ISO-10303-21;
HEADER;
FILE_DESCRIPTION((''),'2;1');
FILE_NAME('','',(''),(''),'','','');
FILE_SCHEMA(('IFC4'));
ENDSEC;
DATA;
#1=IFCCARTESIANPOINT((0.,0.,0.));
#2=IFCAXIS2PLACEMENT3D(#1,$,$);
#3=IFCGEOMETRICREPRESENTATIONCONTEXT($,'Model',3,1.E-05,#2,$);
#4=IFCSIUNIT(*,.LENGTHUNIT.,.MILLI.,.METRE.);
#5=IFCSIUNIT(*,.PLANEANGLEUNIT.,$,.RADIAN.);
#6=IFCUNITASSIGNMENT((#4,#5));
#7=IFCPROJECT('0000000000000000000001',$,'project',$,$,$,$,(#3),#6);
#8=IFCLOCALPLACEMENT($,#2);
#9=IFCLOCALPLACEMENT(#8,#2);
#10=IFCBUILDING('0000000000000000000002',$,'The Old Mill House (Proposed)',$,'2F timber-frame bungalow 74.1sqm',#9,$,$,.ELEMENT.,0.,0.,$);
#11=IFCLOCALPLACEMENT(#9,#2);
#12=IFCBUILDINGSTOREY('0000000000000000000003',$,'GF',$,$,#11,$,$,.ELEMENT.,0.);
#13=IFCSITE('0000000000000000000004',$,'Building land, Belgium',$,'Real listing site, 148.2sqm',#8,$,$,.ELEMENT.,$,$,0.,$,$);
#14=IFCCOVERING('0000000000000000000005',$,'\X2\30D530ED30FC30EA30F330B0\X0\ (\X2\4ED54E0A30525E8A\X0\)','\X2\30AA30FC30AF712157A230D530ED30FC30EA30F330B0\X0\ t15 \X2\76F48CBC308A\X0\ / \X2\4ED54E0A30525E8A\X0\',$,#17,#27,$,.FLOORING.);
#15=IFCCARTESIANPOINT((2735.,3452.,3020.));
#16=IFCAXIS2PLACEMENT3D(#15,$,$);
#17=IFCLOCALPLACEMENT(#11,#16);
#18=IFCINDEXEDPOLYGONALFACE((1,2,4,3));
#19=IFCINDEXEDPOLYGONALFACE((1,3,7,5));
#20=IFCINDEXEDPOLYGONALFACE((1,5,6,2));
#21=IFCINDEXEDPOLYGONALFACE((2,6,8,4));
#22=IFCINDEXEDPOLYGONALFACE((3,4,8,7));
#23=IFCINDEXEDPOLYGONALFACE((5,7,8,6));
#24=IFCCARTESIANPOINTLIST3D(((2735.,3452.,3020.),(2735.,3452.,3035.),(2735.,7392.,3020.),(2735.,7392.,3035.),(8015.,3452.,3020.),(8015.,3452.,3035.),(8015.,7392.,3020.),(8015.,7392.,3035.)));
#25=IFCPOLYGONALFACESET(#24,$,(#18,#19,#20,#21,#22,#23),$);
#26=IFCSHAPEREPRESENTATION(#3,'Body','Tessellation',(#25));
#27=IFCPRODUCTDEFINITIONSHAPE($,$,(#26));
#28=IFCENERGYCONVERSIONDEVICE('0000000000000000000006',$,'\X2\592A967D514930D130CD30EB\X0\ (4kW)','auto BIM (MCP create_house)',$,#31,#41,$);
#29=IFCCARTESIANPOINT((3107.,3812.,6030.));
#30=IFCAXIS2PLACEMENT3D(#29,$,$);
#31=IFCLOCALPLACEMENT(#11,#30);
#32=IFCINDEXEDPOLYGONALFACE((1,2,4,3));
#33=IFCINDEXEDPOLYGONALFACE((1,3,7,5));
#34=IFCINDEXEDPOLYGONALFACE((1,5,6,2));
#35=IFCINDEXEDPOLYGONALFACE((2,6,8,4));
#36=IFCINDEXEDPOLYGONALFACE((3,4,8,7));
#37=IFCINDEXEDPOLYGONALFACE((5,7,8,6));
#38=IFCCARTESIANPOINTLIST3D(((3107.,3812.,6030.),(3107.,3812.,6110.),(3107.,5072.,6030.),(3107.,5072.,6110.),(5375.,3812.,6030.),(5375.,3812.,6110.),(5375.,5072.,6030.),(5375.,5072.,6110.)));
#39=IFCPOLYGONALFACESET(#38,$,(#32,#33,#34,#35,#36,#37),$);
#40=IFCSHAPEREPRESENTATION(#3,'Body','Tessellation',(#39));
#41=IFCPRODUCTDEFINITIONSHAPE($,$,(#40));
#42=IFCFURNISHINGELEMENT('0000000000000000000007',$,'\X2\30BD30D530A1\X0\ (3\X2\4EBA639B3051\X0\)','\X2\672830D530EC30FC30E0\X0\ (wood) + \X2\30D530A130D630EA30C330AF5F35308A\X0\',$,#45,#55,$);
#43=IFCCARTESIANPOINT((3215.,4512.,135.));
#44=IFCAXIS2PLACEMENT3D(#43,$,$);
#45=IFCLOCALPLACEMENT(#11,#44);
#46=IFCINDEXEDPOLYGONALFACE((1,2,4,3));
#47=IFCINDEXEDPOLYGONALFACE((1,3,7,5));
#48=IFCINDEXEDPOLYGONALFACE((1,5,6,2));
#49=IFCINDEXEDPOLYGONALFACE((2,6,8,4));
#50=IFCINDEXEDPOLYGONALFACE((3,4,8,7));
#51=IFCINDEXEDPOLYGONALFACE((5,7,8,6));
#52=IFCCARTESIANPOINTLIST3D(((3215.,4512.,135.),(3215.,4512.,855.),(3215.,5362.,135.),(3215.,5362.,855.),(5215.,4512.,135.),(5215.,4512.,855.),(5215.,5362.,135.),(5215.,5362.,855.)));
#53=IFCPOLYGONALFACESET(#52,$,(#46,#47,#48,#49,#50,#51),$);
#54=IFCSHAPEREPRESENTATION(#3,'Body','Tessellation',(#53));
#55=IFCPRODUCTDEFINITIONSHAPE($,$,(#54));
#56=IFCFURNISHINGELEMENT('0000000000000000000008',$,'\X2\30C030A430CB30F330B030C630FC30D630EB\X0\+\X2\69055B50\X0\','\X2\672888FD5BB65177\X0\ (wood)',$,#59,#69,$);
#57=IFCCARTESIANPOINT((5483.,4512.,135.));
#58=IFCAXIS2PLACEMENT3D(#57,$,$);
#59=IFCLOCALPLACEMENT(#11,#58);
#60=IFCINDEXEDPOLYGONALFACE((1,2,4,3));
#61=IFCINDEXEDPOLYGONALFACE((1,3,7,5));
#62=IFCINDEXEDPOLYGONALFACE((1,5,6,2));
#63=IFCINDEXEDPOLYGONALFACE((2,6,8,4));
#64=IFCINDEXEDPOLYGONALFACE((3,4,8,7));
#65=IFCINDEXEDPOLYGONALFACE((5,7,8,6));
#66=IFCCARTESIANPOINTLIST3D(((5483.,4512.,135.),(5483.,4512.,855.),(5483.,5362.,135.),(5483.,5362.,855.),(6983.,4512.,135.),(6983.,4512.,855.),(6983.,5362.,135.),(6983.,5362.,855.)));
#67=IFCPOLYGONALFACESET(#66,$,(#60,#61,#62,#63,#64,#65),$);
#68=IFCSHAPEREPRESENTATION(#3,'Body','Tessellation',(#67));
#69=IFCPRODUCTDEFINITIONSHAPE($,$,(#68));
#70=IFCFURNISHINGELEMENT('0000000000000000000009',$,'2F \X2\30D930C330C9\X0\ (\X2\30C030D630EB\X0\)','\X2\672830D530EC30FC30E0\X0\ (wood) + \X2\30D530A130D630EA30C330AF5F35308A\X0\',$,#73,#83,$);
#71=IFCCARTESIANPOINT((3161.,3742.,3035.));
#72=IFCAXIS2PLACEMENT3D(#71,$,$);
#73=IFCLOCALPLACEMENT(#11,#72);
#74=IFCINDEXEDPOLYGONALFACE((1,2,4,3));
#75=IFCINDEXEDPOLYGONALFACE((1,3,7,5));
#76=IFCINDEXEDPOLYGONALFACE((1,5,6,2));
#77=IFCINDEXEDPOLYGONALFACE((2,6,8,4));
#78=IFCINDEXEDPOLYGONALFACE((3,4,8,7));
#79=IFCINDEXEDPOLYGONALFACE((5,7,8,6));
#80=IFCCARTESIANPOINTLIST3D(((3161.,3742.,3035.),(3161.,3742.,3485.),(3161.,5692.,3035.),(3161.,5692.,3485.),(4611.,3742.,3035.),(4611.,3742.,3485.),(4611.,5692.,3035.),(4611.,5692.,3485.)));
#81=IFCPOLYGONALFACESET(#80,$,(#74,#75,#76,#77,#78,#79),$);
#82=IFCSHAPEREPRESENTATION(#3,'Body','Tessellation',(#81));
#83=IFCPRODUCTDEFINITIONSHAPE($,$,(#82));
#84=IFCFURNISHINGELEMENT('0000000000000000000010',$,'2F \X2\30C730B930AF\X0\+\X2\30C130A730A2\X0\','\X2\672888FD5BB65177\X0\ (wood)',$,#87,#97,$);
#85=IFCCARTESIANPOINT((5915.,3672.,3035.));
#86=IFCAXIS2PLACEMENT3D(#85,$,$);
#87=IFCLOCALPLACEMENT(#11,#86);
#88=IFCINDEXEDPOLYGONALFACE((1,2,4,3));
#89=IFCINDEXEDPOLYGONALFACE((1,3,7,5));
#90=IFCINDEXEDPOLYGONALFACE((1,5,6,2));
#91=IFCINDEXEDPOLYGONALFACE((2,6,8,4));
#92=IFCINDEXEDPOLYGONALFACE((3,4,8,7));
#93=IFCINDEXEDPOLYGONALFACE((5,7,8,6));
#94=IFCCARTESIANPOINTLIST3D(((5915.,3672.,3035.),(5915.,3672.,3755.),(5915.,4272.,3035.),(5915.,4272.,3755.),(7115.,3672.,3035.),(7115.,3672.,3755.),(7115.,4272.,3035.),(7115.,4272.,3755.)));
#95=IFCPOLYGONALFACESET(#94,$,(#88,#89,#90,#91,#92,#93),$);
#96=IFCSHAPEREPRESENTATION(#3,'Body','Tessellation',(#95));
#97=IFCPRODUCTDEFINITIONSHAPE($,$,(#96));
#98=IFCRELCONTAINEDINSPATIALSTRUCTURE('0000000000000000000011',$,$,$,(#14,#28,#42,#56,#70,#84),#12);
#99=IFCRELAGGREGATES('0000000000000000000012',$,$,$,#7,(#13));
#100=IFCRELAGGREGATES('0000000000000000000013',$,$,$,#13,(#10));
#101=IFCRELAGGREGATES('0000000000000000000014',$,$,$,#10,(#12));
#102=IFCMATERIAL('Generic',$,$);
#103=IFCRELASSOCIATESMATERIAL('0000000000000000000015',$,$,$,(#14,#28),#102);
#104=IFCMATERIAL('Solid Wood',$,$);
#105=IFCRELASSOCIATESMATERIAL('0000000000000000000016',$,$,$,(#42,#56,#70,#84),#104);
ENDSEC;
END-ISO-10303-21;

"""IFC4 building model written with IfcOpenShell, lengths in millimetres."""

from ifc_helpers import new_model, si_unit, frame, frame_2d, origin, place, context, project, spatial, rectangle, extrude, material, element, save


model = new_model("IFC4")

# Units and contexts
model_context = context("Model", 3, precision=1e-05, world=origin())
ifc_project = project(units=[si_unit("LENGTHUNIT", "METRE", prefix="MILLI"), si_unit("PLANEANGLEUNIT", "RADIAN")], contexts=[model_context])

# Site, building, storey
site_placement = place(None, origin())
site = spatial("IfcSite", under=ifc_project, at=site_placement, Name="Building land, Belgium", ObjectType="Real listing site, 148.2sqm", CompositionType="ELEMENT", RefElevation=0.0)
building_placement = place(site_placement, origin())
building = spatial("IfcBuilding", under=site, at=building_placement, Name="The Old Mill House (Proposed)", ObjectType="2F timber-frame bungalow 74.1sqm", CompositionType="ELEMENT", ElevationOfRefHeight=0.0, ElevationOfTerrain=0.0)
storey_placement = place(building_placement, origin())
storey = spatial("IfcBuildingStorey", under=building, at=storey_placement, Name="GF", CompositionType="ELEMENT", Elevation=0.0)

# Shared definitions
ifc_material_1 = material(Name="Solid Wood")

# Covering
ifc_material_2 = material(Name="Generic")
covering_placement = place(storey_placement, frame((2735.0, 3452.0, 3020.0)))
element("IfcCovering", 1, at=covering_placement, inside=storey, material=ifc_material_2, Name="フローリング (仕上げ床)", Description="オーク無垢フローリング t15 直貼り / 仕上げ床", PredefinedType="FLOORING", context=model_context, shape_type="SweptSolid", body=[
    extrude(rectangle(XDim=5280.0, YDim=3940.0, at=frame_2d((2640.0, 1970.0))), frame((2735.0, 3452.0, 3020.0)), (0.0, 0.0, 1.0), 15.0),
])

# Energy conversion device
energy_conversion_device_placement = place(storey_placement, frame((3107.0, 3812.0, 6030.0)))
element("IfcEnergyConversionDevice", 2, at=energy_conversion_device_placement, inside=storey, material=ifc_material_2, Name="太陽光パネル (4kW)", Description="auto BIM (MCP create_house)", context=model_context, shape_type="SweptSolid", body=[
    extrude(rectangle(XDim=2268.0, YDim=1260.0, at=frame_2d((1134.0, 630.0))), frame((3107.0, 3812.0, 6030.0)), (0.0, 0.0, 1.0), 80.0),
])

# Furnishing elements
furnishing_1_placement = place(storey_placement, frame((3215.0, 4512.0, 135.0)))
element("IfcFurnishingElement", 3, at=furnishing_1_placement, inside=storey, material=ifc_material_1, Name="ソファ (3人掛け)", Description="木フレーム (wood) + ファブリック張り", context=model_context, shape_type="SweptSolid", body=[
    extrude(rectangle(XDim=2000.0, YDim=850.0, at=frame_2d((1000.0, 425.0))), frame((3215.0, 4512.0, 135.0)), (0.0, 0.0, 1.0), 720.0),
])
furnishing_2_placement = place(storey_placement, frame((5483.0, 4512.0, 135.0)))
element("IfcFurnishingElement", 4, at=furnishing_2_placement, inside=storey, material=ifc_material_1, Name="ダイニングテーブル+椅子", Description="木製家具 (wood)", context=model_context, shape_type="SweptSolid", body=[
    extrude(rectangle(XDim=1500.0, YDim=850.0, at=frame_2d((750.0, 425.0))), frame((5483.0, 4512.0, 135.0)), (0.0, 0.0, 1.0), 720.0),
])
furnishing_3_placement = place(storey_placement, frame((3161.0, 3742.0, 3035.0)))
element("IfcFurnishingElement", 5, at=furnishing_3_placement, inside=storey, material=ifc_material_1, Name="2F ベッド (ダブル)", Description="木フレーム (wood) + ファブリック張り", context=model_context, shape_type="SweptSolid", body=[
    extrude(rectangle(XDim=1450.0, YDim=1950.0, at=frame_2d((725.0, 975.0))), frame((3161.0, 3742.0, 3035.0)), (0.0, 0.0, 1.0), 450.0),
])
furnishing_4_placement = place(storey_placement, frame((5915.0, 3672.0, 3035.0)))
element("IfcFurnishingElement", 6, at=furnishing_4_placement, inside=storey, material=ifc_material_1, Name="2F デスク+チェア", Description="木製家具 (wood)", context=model_context, shape_type="SweptSolid", body=[
    extrude(rectangle(XDim=1200.0, YDim=600.0, at=frame_2d((600.0, 300.0))), frame((5915.0, 3672.0, 3035.0)), (0.0, 0.0, 1.0), 720.0),
])

save(model, "model.ifc")
